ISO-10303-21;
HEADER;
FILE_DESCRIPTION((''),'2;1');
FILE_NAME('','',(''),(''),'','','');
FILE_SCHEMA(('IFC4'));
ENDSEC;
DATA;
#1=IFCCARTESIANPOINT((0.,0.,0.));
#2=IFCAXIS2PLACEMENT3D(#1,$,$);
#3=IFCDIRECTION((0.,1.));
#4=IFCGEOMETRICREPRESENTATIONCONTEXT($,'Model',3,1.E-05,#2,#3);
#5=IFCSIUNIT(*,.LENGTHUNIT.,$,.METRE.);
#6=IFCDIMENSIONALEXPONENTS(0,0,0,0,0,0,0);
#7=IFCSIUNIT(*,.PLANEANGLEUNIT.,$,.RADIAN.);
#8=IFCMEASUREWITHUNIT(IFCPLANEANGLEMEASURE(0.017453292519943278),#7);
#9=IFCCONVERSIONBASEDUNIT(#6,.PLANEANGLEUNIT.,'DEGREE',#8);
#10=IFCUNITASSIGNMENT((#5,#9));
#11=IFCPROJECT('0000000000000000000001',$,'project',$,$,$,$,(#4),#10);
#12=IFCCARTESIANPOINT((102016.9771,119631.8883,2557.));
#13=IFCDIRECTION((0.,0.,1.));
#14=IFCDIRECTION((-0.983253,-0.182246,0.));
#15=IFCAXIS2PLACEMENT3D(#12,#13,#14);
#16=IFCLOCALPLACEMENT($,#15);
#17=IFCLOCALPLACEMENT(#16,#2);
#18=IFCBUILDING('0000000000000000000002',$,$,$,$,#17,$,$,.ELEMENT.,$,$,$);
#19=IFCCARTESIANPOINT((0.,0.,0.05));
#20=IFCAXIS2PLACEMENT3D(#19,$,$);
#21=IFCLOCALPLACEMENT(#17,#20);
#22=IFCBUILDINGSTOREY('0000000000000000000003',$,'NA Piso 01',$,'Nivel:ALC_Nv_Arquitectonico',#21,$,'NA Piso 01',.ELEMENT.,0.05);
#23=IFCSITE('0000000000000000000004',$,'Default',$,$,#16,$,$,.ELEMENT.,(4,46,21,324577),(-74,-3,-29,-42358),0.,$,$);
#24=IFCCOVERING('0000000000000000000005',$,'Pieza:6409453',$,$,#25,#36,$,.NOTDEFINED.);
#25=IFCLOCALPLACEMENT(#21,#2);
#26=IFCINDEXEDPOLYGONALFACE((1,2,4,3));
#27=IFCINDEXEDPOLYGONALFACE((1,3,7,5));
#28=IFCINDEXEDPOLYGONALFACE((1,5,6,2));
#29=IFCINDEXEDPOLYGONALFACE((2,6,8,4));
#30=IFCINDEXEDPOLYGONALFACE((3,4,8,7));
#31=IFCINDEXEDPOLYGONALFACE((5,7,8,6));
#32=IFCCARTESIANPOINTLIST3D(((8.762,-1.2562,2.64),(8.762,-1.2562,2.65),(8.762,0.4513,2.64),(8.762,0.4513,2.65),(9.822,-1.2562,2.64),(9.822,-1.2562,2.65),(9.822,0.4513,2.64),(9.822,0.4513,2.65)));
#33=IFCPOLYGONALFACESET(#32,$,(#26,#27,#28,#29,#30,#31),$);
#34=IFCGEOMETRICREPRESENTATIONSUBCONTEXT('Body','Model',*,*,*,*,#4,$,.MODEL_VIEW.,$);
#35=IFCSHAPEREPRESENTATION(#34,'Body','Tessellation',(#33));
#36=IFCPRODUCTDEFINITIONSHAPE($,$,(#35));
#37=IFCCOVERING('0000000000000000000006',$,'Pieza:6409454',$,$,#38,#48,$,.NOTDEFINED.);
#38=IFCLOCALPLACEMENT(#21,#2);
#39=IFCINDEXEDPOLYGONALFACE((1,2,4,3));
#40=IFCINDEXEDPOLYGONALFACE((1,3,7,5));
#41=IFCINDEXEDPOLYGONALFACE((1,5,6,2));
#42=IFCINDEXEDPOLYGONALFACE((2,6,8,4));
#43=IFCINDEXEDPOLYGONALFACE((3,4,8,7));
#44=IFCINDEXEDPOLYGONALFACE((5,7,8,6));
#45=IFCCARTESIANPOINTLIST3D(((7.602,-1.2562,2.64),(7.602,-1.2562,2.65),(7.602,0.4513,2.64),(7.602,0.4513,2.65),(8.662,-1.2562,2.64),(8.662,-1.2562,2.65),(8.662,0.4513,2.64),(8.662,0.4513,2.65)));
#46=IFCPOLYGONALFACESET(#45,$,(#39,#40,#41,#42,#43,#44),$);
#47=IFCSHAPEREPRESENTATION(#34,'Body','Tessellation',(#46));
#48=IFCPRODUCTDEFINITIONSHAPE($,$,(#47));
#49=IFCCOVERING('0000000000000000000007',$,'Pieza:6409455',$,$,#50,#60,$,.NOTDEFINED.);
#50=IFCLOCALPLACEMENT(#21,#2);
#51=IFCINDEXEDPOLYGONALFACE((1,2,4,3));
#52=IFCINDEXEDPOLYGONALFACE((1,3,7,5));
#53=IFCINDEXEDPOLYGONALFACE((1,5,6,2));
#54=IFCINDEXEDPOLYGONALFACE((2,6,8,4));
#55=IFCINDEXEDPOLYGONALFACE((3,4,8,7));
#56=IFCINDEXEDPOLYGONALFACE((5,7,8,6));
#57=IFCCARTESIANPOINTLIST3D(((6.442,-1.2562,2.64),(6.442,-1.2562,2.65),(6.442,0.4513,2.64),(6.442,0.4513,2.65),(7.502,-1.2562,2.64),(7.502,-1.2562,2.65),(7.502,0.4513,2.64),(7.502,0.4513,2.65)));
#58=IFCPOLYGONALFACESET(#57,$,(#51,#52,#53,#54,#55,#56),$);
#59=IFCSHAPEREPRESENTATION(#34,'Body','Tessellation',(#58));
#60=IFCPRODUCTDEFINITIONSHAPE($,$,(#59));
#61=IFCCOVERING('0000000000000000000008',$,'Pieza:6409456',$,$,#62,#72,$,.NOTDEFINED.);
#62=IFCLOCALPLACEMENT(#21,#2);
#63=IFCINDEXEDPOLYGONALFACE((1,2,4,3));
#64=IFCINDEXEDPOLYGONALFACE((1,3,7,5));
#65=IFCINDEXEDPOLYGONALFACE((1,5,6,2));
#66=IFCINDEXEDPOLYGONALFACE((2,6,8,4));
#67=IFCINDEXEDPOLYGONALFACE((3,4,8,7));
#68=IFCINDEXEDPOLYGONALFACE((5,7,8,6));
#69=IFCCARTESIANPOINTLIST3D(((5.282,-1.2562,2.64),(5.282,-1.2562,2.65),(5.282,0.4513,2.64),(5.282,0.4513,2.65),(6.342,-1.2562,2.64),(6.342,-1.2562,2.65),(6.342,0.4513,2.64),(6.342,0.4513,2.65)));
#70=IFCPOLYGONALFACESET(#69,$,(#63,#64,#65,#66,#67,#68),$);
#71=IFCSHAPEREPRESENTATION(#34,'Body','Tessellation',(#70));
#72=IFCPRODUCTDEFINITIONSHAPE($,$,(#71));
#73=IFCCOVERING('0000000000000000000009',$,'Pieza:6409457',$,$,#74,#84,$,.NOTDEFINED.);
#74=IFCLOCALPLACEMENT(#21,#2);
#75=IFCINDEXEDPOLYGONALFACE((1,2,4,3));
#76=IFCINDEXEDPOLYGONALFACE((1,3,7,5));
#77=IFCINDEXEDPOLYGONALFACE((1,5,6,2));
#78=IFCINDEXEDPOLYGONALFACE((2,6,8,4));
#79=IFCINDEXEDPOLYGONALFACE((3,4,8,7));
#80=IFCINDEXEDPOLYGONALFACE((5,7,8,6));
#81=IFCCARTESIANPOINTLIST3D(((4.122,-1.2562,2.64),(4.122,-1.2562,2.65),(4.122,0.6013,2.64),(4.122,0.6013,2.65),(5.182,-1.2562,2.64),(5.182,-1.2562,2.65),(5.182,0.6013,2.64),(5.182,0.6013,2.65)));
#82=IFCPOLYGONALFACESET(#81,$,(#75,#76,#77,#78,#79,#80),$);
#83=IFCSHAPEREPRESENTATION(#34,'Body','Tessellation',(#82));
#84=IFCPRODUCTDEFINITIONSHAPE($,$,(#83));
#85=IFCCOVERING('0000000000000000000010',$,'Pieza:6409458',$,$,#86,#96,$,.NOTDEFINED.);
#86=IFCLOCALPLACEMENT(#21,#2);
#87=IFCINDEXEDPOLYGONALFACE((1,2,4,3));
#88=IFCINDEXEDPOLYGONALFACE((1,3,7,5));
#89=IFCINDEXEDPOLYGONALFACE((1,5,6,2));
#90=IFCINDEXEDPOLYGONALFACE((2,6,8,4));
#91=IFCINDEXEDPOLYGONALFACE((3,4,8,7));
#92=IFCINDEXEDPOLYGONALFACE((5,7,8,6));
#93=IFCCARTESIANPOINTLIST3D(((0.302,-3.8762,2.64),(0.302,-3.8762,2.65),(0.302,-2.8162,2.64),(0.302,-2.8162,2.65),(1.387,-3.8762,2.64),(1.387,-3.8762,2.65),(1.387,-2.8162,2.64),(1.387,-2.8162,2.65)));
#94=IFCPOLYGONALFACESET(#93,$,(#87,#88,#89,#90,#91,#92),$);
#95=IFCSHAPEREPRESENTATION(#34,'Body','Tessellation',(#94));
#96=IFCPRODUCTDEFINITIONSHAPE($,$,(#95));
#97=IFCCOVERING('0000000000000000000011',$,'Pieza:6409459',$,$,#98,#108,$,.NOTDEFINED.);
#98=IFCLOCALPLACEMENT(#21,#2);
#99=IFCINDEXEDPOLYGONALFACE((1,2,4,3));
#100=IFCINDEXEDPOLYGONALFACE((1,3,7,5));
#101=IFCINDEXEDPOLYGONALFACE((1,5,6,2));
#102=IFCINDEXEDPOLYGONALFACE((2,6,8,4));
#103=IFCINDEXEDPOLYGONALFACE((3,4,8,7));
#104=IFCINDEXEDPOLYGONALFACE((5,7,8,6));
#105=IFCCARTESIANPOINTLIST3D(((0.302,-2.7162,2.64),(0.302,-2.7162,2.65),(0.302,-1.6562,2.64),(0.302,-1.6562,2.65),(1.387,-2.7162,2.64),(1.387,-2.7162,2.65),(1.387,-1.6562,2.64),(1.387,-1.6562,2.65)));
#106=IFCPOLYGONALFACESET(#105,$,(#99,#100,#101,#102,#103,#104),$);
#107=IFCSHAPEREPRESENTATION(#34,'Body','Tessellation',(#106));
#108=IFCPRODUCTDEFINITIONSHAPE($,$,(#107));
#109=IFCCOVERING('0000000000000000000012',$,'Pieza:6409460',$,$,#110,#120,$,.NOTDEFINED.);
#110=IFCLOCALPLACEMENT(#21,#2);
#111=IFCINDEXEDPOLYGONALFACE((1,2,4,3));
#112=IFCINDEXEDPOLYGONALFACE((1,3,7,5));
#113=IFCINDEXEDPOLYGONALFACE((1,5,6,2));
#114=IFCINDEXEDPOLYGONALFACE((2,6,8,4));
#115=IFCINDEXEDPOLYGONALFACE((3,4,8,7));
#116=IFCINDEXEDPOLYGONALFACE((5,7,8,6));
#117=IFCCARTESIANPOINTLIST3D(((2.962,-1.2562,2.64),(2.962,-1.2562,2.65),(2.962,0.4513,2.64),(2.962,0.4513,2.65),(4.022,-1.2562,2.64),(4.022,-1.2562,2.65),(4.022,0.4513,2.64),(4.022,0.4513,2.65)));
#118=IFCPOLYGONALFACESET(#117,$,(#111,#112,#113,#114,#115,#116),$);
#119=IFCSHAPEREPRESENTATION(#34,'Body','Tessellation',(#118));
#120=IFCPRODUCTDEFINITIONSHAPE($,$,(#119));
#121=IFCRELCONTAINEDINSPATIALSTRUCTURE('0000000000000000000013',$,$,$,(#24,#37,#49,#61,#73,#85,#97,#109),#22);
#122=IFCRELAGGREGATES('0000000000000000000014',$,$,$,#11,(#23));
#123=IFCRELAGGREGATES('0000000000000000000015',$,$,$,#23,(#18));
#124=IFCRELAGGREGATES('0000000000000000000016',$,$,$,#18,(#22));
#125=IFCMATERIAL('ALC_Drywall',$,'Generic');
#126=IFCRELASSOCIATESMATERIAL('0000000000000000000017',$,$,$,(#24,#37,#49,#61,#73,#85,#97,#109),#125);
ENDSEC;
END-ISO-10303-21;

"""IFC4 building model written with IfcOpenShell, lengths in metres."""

from ifc_helpers import new_model, entity, si_unit, converted_unit, direction, frame, frame_2d, origin, place, context, subcontext, project, spatial, rectangle, extrude, material, element, save


model = new_model("IFC4")

# Units and contexts
model_context = context("Model", 3, precision=1e-05, world=origin(), true_north=direction((0.0, 1.0)))
body_context = subcontext(model_context, "Body", "Model", "MODEL_VIEW")
ifc_project = project(units=[si_unit("LENGTHUNIT", "METRE"), converted_unit("PLANEANGLEUNIT", "DEGREE", entity("IfcPlaneAngleMeasure", 0.017453292519943278), si_unit("PLANEANGLEUNIT", "RADIAN"), dimensions=[0, 0, 0, 0, 0, 0, 0])], contexts=[model_context])

# Site, building, storey
site_placement = place(None, frame((102016.9771, 119631.8883, 2557.0), z_axis=(0.0, 0.0, 1.0), x_axis=(-0.983253, -0.182246, 0.0)))
site = spatial("IfcSite", under=ifc_project, at=site_placement, Name="Default", CompositionType="ELEMENT", RefLatitude=(4, 46, 21, 324577), RefLongitude=(-74, -3, -29, -42358), RefElevation=0.0)
building_placement = place(site_placement, origin())
building = spatial("IfcBuilding", under=site, at=building_placement, CompositionType="ELEMENT")
storey_placement = place(building_placement, frame((0.0, 0.0, 0.05)))
storey = spatial("IfcBuildingStorey", under=building, at=storey_placement, Name="NA Piso 01", ObjectType="Nivel:ALC_Nv_Arquitectonico", LongName="NA Piso 01", CompositionType="ELEMENT", Elevation=0.05)

# Coverings
ifc_material_1 = material(Name="ALC_Drywall", Category="Generic")
covering_1_placement = place(storey_placement, frame((0.0, 0.0, 2.64)))
element("IfcCovering", 1, at=covering_1_placement, inside=storey, material=ifc_material_1, Name="Pieza:6409453", PredefinedType="NOTDEFINED", context=body_context, shape_type="SweptSolid", body=[
    extrude(rectangle(XDim=1.7075, YDim=1.06, at=frame_2d((0.0, 0.0), x_axis=(1.0, 0.0))), frame((9.292, -0.4024, 0.0), z_axis=(0.0, 0.0, 1.0), x_axis=(0.0, -1.0, 0.0)), (0.0, 0.0, 1.0), 0.01),
])
covering_2_placement = place(storey_placement, frame((0.0, 0.0, 2.64)))
element("IfcCovering", 2, at=covering_2_placement, inside=storey, material=ifc_material_1, Name="Pieza:6409454", PredefinedType="NOTDEFINED", context=body_context, shape_type="SweptSolid", body=[
    extrude(rectangle(XDim=1.7075, YDim=1.06, at=frame_2d((0.0, 0.0), x_axis=(1.0, 0.0))), frame((8.132, -0.4024, 0.0), z_axis=(0.0, 0.0, 1.0), x_axis=(0.0, -1.0, 0.0)), (0.0, 0.0, 1.0), 0.01),
])
covering_3_placement = place(storey_placement, frame((0.0, 0.0, 2.64)))
element("IfcCovering", 3, at=covering_3_placement, inside=storey, material=ifc_material_1, Name="Pieza:6409455", PredefinedType="NOTDEFINED", context=body_context, shape_type="SweptSolid", body=[
    extrude(rectangle(XDim=1.7075, YDim=1.06, at=frame_2d((0.0, 0.0), x_axis=(1.0, 0.0))), frame((6.972, -0.4024, 0.0), z_axis=(0.0, 0.0, 1.0), x_axis=(0.0, -1.0, 0.0)), (0.0, 0.0, 1.0), 0.01),
])
covering_4_placement = place(storey_placement, frame((0.0, 0.0, 2.64)))
element("IfcCovering", 4, at=covering_4_placement, inside=storey, material=ifc_material_1, Name="Pieza:6409456", PredefinedType="NOTDEFINED", context=body_context, shape_type="SweptSolid", body=[
    extrude(rectangle(XDim=1.7075, YDim=1.06, at=frame_2d((0.0, 0.0), x_axis=(1.0, 0.0))), frame((5.812, -0.4024, 0.0), z_axis=(0.0, 0.0, 1.0), x_axis=(0.0, -1.0, 0.0)), (0.0, 0.0, 1.0), 0.01),
])
covering_5_placement = place(storey_placement, frame((0.0, 0.0, 2.64)))
element("IfcCovering", 5, at=covering_5_placement, inside=storey, material=ifc_material_1, Name="Pieza:6409457", PredefinedType="NOTDEFINED", context=body_context, shape_type="SweptSolid", body=[
    extrude(rectangle(XDim=1.8575, YDim=1.06, at=frame_2d((0.0, 0.0), x_axis=(1.0, 0.0))), frame((4.652, -0.3274, 0.0), z_axis=(0.0, 0.0, 1.0), x_axis=(0.0, -1.0, 0.0)), (0.0, 0.0, 1.0), 0.01),
])
covering_6_placement = place(storey_placement, frame((0.0, 0.0, 2.64)))
element("IfcCovering", 6, at=covering_6_placement, inside=storey, material=ifc_material_1, Name="Pieza:6409458", PredefinedType="NOTDEFINED", context=body_context, shape_type="SweptSolid", body=[
    extrude(rectangle(XDim=1.06, YDim=1.085, at=frame_2d((0.0, 0.0), x_axis=(1.0, 0.0))), frame((0.8445, -3.3462, 0.0), z_axis=(0.0, 0.0, 1.0), x_axis=(0.0, -1.0, 0.0)), (0.0, 0.0, 1.0), 0.01),
])
covering_7_placement = place(storey_placement, frame((0.0, 0.0, 2.64)))
element("IfcCovering", 7, at=covering_7_placement, inside=storey, material=ifc_material_1, Name="Pieza:6409459", PredefinedType="NOTDEFINED", context=body_context, shape_type="SweptSolid", body=[
    extrude(rectangle(XDim=1.06, YDim=1.085, at=frame_2d((0.0, 0.0), x_axis=(1.0, 0.0))), frame((0.8445, -2.1862, 0.0), z_axis=(0.0, 0.0, 1.0), x_axis=(0.0, -1.0, 0.0)), (0.0, 0.0, 1.0), 0.01),
])
covering_8_placement = place(storey_placement, frame((0.0, 0.0, 2.64)))
element("IfcCovering", 8, at=covering_8_placement, inside=storey, material=ifc_material_1, Name="Pieza:6409460", PredefinedType="NOTDEFINED", context=body_context, shape_type="SweptSolid", body=[
    extrude(rectangle(XDim=1.7075, YDim=1.06, at=frame_2d((0.0, 0.0), x_axis=(1.0, 0.0))), frame((3.492, -0.4024, 0.0), z_axis=(0.0, 0.0, 1.0), x_axis=(0.0, -1.0, 0.0)), (0.0, 0.0, 1.0), 0.01),
])

save(model, "model.ifc")
